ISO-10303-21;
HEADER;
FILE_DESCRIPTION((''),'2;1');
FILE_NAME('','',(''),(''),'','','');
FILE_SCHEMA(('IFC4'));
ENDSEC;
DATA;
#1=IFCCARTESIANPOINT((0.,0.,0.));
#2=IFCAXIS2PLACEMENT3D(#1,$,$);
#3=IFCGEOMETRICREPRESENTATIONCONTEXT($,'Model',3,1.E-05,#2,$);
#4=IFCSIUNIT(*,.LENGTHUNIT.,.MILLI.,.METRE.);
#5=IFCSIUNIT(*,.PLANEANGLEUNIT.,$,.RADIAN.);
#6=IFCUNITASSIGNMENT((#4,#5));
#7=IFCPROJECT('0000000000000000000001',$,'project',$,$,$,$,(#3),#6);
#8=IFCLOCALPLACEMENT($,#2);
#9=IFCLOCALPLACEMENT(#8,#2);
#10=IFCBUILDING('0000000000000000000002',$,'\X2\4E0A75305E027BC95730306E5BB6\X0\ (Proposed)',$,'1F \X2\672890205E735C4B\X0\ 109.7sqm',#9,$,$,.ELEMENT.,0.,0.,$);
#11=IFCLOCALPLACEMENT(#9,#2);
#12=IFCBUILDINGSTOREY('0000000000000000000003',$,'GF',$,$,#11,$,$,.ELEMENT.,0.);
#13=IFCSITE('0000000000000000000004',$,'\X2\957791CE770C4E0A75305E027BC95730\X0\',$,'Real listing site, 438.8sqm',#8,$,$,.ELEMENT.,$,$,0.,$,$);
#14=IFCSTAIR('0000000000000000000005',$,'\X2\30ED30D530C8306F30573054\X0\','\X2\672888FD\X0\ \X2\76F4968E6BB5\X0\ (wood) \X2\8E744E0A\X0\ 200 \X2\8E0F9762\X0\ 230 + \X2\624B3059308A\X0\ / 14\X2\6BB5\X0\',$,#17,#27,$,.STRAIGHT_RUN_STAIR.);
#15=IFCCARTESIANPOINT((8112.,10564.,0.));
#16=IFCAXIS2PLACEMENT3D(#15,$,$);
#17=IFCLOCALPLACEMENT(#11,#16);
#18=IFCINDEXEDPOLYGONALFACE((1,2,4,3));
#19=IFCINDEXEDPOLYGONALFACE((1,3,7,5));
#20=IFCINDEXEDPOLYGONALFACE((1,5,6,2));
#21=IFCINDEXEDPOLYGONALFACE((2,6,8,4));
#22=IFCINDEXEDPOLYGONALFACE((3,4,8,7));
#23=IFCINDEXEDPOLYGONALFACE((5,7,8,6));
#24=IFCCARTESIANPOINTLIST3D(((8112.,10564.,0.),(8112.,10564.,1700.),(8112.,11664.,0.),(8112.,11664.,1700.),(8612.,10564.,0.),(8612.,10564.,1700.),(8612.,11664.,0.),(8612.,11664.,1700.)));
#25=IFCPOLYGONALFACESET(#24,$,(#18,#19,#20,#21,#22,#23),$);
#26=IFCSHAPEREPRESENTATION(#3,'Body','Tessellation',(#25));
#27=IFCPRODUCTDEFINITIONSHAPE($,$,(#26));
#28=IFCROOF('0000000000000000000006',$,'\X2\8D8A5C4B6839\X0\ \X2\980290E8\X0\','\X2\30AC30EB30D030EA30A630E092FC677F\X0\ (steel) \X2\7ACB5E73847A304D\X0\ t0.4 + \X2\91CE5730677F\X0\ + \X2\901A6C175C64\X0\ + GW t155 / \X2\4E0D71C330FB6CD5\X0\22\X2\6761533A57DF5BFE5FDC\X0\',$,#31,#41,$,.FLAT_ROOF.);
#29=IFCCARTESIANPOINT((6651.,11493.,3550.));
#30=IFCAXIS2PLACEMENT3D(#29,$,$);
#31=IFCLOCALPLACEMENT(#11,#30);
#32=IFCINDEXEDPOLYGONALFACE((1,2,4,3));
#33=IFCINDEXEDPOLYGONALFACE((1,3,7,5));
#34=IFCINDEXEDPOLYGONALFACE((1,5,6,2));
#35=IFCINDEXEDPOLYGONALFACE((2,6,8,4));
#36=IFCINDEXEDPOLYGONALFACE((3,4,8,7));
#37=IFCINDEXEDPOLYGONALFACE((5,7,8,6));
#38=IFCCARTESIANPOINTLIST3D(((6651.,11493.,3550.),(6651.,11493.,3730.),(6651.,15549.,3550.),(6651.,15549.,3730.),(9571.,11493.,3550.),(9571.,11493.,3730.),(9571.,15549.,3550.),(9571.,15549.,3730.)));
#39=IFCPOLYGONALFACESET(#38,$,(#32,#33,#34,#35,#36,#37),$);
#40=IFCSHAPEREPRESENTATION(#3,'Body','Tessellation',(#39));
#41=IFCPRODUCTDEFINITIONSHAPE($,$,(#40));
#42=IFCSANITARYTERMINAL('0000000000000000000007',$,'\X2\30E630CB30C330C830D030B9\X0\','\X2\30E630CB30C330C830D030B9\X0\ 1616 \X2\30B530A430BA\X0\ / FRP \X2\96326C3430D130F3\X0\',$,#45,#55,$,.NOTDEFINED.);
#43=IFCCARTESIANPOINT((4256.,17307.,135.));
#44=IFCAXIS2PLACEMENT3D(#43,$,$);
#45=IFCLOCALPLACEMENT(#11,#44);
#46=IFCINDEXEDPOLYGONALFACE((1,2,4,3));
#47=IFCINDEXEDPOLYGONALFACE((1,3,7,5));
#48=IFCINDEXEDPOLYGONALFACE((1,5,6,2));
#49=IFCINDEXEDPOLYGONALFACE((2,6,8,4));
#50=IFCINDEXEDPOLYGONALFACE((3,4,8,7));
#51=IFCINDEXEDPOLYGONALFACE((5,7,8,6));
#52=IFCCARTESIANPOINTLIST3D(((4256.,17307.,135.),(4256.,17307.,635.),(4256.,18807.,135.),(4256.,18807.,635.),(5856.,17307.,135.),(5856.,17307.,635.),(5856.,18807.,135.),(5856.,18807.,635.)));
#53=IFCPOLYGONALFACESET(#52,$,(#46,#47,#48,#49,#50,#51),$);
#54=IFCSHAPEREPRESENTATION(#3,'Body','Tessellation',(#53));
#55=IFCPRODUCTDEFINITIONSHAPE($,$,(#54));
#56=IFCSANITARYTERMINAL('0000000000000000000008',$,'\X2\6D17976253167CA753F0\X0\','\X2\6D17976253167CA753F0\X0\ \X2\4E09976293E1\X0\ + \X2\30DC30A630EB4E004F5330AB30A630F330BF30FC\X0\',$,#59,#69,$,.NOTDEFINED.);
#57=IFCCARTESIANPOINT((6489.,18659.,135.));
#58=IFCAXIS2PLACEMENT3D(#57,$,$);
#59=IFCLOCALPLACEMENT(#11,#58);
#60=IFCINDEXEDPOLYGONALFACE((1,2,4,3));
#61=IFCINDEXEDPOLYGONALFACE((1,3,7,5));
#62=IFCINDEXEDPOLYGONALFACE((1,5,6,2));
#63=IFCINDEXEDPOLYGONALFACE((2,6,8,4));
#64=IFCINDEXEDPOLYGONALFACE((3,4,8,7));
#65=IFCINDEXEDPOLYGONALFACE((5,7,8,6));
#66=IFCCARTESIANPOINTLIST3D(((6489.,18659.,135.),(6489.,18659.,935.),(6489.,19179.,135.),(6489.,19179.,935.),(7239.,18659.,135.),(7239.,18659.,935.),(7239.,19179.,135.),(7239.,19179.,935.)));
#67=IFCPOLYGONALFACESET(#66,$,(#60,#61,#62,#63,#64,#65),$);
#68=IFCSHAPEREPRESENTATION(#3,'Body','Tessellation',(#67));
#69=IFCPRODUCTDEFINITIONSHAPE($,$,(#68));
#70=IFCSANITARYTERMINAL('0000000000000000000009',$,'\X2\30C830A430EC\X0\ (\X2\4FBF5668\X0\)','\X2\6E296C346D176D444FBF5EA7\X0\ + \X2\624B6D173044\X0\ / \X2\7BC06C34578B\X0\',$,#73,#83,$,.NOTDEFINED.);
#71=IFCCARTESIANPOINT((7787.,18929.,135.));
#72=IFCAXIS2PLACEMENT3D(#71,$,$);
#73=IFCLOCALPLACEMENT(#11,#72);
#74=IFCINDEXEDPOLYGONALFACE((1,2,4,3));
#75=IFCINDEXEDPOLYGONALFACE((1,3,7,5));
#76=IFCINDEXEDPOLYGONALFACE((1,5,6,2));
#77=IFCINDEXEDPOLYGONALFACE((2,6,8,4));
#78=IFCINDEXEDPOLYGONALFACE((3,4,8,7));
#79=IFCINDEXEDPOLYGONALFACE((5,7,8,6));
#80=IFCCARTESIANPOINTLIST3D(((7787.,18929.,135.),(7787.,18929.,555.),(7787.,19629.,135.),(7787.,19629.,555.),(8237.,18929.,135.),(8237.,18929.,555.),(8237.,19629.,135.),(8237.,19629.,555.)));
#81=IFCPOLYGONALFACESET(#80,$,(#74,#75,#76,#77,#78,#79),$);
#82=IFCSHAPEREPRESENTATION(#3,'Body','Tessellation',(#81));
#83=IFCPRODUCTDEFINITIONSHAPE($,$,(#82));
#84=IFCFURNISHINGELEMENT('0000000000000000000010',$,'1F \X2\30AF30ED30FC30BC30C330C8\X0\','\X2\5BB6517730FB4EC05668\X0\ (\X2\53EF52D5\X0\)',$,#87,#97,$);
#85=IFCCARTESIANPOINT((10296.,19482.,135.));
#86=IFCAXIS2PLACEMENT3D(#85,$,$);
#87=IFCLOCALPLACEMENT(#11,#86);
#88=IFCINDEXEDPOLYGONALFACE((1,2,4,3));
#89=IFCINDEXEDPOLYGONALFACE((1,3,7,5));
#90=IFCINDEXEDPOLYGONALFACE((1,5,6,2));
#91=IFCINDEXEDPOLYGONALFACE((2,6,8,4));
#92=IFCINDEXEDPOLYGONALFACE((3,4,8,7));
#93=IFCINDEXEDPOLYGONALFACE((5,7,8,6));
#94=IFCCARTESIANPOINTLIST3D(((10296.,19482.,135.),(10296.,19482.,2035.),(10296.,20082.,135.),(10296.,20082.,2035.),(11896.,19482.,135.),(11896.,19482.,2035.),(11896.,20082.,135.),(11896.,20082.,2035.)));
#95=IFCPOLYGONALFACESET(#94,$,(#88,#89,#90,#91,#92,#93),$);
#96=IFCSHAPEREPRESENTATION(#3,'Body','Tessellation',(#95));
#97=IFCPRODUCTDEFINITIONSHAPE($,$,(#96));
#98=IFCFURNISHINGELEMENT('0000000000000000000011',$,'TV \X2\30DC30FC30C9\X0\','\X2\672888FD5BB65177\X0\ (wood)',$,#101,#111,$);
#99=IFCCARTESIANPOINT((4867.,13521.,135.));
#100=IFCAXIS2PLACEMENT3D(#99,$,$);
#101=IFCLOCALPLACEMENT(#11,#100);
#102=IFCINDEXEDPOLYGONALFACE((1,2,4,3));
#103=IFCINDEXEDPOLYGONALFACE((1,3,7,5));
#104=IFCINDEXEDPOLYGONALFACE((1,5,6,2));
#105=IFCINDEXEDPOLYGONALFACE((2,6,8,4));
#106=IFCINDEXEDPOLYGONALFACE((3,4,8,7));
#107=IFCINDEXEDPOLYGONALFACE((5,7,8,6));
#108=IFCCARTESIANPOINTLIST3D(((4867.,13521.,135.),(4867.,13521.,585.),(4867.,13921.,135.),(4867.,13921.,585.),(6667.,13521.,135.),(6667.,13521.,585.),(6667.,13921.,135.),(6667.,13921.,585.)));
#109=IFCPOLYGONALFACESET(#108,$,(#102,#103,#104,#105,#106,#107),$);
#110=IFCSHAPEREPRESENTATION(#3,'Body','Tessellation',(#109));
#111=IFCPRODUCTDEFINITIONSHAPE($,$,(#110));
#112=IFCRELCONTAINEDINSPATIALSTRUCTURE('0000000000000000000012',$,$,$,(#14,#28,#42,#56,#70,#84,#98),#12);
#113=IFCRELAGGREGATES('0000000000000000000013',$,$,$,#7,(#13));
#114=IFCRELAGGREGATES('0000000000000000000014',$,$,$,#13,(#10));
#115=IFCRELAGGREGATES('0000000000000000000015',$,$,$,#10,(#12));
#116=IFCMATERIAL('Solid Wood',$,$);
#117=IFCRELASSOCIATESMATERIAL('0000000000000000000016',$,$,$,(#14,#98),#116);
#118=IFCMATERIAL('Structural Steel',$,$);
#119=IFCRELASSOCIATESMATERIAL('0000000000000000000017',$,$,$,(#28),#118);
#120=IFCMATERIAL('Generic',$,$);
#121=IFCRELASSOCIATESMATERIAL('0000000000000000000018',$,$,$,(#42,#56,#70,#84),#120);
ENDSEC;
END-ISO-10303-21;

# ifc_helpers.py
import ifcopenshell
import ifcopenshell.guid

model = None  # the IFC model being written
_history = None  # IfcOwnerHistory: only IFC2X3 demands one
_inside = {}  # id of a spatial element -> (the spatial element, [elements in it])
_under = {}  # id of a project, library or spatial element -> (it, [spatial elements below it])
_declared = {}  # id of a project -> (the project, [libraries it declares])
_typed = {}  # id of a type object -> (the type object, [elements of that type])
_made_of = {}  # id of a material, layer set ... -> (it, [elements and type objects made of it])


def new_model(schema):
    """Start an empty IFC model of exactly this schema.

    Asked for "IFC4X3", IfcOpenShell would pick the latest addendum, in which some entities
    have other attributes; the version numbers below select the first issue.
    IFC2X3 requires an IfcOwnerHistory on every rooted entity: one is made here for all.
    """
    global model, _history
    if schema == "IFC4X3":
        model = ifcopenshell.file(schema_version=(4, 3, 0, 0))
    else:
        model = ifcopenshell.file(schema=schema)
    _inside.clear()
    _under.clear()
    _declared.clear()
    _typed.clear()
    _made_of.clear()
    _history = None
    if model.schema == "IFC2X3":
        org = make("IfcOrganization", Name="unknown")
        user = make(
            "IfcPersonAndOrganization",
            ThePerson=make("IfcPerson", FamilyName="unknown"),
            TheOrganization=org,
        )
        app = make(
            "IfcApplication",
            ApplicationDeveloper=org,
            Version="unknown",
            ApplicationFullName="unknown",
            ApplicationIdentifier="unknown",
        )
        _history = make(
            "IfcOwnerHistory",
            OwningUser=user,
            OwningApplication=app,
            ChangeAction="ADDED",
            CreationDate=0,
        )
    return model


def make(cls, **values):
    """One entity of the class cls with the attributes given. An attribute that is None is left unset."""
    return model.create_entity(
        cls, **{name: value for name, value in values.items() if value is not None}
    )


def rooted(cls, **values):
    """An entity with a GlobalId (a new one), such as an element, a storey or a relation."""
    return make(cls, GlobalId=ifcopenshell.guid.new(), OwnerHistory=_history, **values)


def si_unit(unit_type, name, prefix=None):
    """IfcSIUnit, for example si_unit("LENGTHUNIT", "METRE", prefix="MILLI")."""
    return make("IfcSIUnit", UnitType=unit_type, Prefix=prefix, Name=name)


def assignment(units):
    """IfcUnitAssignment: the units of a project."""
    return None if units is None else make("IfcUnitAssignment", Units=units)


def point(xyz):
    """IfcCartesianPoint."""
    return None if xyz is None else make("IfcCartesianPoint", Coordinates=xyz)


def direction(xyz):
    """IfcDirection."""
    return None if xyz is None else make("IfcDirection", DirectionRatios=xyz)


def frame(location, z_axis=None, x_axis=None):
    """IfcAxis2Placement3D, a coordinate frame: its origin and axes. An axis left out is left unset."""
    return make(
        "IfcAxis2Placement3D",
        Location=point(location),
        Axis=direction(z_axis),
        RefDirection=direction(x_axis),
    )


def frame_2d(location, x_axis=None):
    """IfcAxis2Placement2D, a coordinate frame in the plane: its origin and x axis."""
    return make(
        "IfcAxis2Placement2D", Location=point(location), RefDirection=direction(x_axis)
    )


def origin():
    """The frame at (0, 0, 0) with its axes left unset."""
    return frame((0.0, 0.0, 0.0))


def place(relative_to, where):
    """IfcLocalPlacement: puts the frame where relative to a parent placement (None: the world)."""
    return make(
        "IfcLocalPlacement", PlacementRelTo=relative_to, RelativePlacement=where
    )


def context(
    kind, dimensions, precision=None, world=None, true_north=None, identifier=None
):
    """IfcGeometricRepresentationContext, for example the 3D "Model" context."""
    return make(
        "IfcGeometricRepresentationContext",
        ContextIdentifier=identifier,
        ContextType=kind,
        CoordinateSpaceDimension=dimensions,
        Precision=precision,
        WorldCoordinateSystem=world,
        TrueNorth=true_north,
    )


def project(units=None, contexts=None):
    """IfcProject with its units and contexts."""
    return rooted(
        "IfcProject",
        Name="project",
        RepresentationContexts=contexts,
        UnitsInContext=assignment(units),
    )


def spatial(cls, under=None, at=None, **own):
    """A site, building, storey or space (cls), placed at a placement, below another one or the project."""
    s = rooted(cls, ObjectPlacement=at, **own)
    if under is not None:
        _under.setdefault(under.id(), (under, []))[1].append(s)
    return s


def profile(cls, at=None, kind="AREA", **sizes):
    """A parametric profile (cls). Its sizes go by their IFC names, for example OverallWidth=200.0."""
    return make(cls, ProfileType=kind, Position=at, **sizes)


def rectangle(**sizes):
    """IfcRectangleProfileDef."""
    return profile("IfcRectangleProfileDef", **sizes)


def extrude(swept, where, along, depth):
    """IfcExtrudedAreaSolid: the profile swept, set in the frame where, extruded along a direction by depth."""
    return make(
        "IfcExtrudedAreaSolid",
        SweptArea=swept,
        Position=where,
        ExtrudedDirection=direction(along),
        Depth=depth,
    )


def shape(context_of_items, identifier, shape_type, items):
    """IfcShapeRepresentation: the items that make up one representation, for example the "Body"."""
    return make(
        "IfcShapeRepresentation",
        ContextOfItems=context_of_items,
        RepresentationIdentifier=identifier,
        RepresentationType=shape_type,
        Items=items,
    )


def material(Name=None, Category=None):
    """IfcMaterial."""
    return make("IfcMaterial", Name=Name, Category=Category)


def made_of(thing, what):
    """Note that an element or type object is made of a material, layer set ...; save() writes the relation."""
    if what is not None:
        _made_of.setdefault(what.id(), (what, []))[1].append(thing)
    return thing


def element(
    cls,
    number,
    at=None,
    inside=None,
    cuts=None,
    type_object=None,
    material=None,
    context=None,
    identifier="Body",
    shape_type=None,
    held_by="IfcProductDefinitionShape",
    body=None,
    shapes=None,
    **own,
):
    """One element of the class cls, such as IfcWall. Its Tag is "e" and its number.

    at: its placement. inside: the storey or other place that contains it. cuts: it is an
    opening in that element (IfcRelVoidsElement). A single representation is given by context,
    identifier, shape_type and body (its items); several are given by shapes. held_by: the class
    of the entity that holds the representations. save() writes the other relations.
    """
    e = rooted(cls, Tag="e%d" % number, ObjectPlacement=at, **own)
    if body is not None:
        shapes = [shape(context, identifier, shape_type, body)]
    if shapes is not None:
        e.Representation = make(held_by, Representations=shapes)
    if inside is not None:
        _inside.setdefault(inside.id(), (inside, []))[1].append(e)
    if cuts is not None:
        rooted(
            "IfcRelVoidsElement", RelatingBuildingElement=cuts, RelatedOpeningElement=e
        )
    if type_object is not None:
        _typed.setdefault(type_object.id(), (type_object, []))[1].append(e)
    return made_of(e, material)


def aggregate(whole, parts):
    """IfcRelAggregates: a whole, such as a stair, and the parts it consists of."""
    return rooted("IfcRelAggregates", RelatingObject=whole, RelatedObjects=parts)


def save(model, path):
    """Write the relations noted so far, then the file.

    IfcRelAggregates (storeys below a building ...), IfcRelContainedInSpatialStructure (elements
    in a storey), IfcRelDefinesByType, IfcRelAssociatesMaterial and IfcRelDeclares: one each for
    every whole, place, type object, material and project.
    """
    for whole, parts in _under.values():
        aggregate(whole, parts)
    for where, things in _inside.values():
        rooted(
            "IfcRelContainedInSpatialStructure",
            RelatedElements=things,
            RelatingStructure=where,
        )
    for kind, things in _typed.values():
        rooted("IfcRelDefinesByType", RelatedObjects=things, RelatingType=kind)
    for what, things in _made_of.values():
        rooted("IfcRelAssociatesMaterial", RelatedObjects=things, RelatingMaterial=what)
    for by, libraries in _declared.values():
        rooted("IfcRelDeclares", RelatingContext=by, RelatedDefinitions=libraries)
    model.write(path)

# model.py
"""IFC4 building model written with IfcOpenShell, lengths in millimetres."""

from ifc_helpers import new_model, si_unit, frame, frame_2d, origin, place, context, project, spatial, rectangle, extrude, material, element, save


model = new_model("IFC4")

# Units and contexts
model_context = context("Model", 3, precision=1e-05, world=origin())
ifc_project = project(units=[si_unit("LENGTHUNIT", "METRE", prefix="MILLI"), si_unit("PLANEANGLEUNIT", "RADIAN")], contexts=[model_context])

# Site, building, storey
site_placement = place(None, origin())
site = spatial("IfcSite", under=ifc_project, at=site_placement, Name="長野県上田市築地", ObjectType="Real listing site, 438.8sqm", CompositionType="ELEMENT", RefElevation=0.0)
building_placement = place(site_placement, origin())
building = spatial("IfcBuilding", under=site, at=building_placement, Name="上田市築地の家 (Proposed)", ObjectType="1F 木造平屋 109.7sqm", CompositionType="ELEMENT", ElevationOfRefHeight=0.0, ElevationOfTerrain=0.0)
storey_placement = place(building_placement, origin())
storey = spatial("IfcBuildingStorey", under=building, at=storey_placement, Name="GF", CompositionType="ELEMENT", Elevation=0.0)

# Shared definitions
ifc_material_1 = material(Name="Solid Wood")

# Stair
stair_placement = place(storey_placement, frame((8112.0, 10564.0, 0.0)))
element("IfcStair", 1, at=stair_placement, inside=storey, material=ifc_material_1, Name="ロフトはしご", Description="木製 直階段 (wood) 蹴上 200 踏面 230 + 手すり / 14段", PredefinedType="STRAIGHT_RUN_STAIR", context=model_context, shape_type="SweptSolid", body=[
    extrude(rectangle(XDim=500.0, YDim=1100.0, at=frame_2d((250.0, 550.0))), frame((8112.0, 10564.0, 0.0)), (0.0, 0.0, 1.0), 1700.0),
])

# Roof
ifc_material_2 = material(Name="Structural Steel")
roof_placement = place(storey_placement, frame((6651.0, 11493.0, 3550.0)))
element("IfcRoof", 2, at=roof_placement, inside=storey, material=ifc_material_2, Name="越屋根 頂部", Description="ガルバリウム鋼板 (steel) 立平葺き t0.4 + 野地板 + 通気層 + GW t155 / 不燃・法22条区域対応", PredefinedType="FLAT_ROOF", context=model_context, shape_type="SweptSolid", body=[
    extrude(rectangle(XDim=2920.0, YDim=4056.0, at=frame_2d((1460.0, 2028.0))), frame((6651.0, 11493.0, 3550.0)), (0.0, 0.0, 1.0), 180.0),
])

# Sanitary terminals
ifc_material_3 = material(Name="Generic")
sanitary_terminal_1_placement = place(storey_placement, frame((4256.0, 17307.0, 135.0)))
element("IfcSanitaryTerminal", 3, at=sanitary_terminal_1_placement, inside=storey, material=ifc_material_3, Name="ユニットバス", Description="ユニットバス 1616 サイズ / FRP 防水パン", PredefinedType="NOTDEFINED", context=model_context, shape_type="SweptSolid", body=[
    extrude(rectangle(XDim=1600.0, YDim=1500.0, at=frame_2d((800.0, 750.0))), frame((4256.0, 17307.0, 135.0)), (0.0, 0.0, 1.0), 500.0),
])
sanitary_terminal_2_placement = place(storey_placement, frame((6489.0, 18659.0, 135.0)))
element("IfcSanitaryTerminal", 4, at=sanitary_terminal_2_placement, inside=storey, material=ifc_material_3, Name="洗面化粧台", Description="洗面化粧台 三面鏡 + ボウル一体カウンター", PredefinedType="NOTDEFINED", context=model_context, shape_type="SweptSolid", body=[
    extrude(rectangle(XDim=750.0, YDim=520.0, at=frame_2d((375.0, 260.0))), frame((6489.0, 18659.0, 135.0)), (0.0, 0.0, 1.0), 800.0),
])
sanitary_terminal_3_placement = place(storey_placement, frame((7787.0, 18929.0, 135.0)))
element("IfcSanitaryTerminal", 5, at=sanitary_terminal_3_placement, inside=storey, material=ifc_material_3, Name="トイレ (便器)", Description="温水洗浄便座 + 手洗い / 節水型", PredefinedType="NOTDEFINED", context=model_context, shape_type="SweptSolid", body=[
    extrude(rectangle(XDim=450.0, YDim=700.0, at=frame_2d((225.0, 350.0))), frame((7787.0, 18929.0, 135.0)), (0.0, 0.0, 1.0), 420.0),
])

# Furnishing elements
furnishing_1_placement = place(storey_placement, frame((10296.0, 19482.0, 135.0)))
element("IfcFurnishingElement", 6, at=furnishing_1_placement, inside=storey, material=ifc_material_3, Name="1F クローゼット", Description="家具・什器 (可動)", context=model_context, shape_type="SweptSolid", body=[
    extrude(rectangle(XDim=1600.0, YDim=600.0, at=frame_2d((800.0, 300.0))), frame((10296.0, 19482.0, 135.0)), (0.0, 0.0, 1.0), 1900.0),
])
furnishing_2_placement = place(storey_placement, frame((4867.0, 13521.0, 135.0)))
element("IfcFurnishingElement", 7, at=furnishing_2_placement, inside=storey, material=ifc_material_1, Name="TV ボード", Description="木製家具 (wood)", context=model_context, shape_type="SweptSolid", body=[
    extrude(rectangle(XDim=1800.0, YDim=400.0, at=frame_2d((900.0, 200.0))), frame((4867.0, 13521.0, 135.0)), (0.0, 0.0, 1.0), 450.0),
])

save(model, "model.ifc")
